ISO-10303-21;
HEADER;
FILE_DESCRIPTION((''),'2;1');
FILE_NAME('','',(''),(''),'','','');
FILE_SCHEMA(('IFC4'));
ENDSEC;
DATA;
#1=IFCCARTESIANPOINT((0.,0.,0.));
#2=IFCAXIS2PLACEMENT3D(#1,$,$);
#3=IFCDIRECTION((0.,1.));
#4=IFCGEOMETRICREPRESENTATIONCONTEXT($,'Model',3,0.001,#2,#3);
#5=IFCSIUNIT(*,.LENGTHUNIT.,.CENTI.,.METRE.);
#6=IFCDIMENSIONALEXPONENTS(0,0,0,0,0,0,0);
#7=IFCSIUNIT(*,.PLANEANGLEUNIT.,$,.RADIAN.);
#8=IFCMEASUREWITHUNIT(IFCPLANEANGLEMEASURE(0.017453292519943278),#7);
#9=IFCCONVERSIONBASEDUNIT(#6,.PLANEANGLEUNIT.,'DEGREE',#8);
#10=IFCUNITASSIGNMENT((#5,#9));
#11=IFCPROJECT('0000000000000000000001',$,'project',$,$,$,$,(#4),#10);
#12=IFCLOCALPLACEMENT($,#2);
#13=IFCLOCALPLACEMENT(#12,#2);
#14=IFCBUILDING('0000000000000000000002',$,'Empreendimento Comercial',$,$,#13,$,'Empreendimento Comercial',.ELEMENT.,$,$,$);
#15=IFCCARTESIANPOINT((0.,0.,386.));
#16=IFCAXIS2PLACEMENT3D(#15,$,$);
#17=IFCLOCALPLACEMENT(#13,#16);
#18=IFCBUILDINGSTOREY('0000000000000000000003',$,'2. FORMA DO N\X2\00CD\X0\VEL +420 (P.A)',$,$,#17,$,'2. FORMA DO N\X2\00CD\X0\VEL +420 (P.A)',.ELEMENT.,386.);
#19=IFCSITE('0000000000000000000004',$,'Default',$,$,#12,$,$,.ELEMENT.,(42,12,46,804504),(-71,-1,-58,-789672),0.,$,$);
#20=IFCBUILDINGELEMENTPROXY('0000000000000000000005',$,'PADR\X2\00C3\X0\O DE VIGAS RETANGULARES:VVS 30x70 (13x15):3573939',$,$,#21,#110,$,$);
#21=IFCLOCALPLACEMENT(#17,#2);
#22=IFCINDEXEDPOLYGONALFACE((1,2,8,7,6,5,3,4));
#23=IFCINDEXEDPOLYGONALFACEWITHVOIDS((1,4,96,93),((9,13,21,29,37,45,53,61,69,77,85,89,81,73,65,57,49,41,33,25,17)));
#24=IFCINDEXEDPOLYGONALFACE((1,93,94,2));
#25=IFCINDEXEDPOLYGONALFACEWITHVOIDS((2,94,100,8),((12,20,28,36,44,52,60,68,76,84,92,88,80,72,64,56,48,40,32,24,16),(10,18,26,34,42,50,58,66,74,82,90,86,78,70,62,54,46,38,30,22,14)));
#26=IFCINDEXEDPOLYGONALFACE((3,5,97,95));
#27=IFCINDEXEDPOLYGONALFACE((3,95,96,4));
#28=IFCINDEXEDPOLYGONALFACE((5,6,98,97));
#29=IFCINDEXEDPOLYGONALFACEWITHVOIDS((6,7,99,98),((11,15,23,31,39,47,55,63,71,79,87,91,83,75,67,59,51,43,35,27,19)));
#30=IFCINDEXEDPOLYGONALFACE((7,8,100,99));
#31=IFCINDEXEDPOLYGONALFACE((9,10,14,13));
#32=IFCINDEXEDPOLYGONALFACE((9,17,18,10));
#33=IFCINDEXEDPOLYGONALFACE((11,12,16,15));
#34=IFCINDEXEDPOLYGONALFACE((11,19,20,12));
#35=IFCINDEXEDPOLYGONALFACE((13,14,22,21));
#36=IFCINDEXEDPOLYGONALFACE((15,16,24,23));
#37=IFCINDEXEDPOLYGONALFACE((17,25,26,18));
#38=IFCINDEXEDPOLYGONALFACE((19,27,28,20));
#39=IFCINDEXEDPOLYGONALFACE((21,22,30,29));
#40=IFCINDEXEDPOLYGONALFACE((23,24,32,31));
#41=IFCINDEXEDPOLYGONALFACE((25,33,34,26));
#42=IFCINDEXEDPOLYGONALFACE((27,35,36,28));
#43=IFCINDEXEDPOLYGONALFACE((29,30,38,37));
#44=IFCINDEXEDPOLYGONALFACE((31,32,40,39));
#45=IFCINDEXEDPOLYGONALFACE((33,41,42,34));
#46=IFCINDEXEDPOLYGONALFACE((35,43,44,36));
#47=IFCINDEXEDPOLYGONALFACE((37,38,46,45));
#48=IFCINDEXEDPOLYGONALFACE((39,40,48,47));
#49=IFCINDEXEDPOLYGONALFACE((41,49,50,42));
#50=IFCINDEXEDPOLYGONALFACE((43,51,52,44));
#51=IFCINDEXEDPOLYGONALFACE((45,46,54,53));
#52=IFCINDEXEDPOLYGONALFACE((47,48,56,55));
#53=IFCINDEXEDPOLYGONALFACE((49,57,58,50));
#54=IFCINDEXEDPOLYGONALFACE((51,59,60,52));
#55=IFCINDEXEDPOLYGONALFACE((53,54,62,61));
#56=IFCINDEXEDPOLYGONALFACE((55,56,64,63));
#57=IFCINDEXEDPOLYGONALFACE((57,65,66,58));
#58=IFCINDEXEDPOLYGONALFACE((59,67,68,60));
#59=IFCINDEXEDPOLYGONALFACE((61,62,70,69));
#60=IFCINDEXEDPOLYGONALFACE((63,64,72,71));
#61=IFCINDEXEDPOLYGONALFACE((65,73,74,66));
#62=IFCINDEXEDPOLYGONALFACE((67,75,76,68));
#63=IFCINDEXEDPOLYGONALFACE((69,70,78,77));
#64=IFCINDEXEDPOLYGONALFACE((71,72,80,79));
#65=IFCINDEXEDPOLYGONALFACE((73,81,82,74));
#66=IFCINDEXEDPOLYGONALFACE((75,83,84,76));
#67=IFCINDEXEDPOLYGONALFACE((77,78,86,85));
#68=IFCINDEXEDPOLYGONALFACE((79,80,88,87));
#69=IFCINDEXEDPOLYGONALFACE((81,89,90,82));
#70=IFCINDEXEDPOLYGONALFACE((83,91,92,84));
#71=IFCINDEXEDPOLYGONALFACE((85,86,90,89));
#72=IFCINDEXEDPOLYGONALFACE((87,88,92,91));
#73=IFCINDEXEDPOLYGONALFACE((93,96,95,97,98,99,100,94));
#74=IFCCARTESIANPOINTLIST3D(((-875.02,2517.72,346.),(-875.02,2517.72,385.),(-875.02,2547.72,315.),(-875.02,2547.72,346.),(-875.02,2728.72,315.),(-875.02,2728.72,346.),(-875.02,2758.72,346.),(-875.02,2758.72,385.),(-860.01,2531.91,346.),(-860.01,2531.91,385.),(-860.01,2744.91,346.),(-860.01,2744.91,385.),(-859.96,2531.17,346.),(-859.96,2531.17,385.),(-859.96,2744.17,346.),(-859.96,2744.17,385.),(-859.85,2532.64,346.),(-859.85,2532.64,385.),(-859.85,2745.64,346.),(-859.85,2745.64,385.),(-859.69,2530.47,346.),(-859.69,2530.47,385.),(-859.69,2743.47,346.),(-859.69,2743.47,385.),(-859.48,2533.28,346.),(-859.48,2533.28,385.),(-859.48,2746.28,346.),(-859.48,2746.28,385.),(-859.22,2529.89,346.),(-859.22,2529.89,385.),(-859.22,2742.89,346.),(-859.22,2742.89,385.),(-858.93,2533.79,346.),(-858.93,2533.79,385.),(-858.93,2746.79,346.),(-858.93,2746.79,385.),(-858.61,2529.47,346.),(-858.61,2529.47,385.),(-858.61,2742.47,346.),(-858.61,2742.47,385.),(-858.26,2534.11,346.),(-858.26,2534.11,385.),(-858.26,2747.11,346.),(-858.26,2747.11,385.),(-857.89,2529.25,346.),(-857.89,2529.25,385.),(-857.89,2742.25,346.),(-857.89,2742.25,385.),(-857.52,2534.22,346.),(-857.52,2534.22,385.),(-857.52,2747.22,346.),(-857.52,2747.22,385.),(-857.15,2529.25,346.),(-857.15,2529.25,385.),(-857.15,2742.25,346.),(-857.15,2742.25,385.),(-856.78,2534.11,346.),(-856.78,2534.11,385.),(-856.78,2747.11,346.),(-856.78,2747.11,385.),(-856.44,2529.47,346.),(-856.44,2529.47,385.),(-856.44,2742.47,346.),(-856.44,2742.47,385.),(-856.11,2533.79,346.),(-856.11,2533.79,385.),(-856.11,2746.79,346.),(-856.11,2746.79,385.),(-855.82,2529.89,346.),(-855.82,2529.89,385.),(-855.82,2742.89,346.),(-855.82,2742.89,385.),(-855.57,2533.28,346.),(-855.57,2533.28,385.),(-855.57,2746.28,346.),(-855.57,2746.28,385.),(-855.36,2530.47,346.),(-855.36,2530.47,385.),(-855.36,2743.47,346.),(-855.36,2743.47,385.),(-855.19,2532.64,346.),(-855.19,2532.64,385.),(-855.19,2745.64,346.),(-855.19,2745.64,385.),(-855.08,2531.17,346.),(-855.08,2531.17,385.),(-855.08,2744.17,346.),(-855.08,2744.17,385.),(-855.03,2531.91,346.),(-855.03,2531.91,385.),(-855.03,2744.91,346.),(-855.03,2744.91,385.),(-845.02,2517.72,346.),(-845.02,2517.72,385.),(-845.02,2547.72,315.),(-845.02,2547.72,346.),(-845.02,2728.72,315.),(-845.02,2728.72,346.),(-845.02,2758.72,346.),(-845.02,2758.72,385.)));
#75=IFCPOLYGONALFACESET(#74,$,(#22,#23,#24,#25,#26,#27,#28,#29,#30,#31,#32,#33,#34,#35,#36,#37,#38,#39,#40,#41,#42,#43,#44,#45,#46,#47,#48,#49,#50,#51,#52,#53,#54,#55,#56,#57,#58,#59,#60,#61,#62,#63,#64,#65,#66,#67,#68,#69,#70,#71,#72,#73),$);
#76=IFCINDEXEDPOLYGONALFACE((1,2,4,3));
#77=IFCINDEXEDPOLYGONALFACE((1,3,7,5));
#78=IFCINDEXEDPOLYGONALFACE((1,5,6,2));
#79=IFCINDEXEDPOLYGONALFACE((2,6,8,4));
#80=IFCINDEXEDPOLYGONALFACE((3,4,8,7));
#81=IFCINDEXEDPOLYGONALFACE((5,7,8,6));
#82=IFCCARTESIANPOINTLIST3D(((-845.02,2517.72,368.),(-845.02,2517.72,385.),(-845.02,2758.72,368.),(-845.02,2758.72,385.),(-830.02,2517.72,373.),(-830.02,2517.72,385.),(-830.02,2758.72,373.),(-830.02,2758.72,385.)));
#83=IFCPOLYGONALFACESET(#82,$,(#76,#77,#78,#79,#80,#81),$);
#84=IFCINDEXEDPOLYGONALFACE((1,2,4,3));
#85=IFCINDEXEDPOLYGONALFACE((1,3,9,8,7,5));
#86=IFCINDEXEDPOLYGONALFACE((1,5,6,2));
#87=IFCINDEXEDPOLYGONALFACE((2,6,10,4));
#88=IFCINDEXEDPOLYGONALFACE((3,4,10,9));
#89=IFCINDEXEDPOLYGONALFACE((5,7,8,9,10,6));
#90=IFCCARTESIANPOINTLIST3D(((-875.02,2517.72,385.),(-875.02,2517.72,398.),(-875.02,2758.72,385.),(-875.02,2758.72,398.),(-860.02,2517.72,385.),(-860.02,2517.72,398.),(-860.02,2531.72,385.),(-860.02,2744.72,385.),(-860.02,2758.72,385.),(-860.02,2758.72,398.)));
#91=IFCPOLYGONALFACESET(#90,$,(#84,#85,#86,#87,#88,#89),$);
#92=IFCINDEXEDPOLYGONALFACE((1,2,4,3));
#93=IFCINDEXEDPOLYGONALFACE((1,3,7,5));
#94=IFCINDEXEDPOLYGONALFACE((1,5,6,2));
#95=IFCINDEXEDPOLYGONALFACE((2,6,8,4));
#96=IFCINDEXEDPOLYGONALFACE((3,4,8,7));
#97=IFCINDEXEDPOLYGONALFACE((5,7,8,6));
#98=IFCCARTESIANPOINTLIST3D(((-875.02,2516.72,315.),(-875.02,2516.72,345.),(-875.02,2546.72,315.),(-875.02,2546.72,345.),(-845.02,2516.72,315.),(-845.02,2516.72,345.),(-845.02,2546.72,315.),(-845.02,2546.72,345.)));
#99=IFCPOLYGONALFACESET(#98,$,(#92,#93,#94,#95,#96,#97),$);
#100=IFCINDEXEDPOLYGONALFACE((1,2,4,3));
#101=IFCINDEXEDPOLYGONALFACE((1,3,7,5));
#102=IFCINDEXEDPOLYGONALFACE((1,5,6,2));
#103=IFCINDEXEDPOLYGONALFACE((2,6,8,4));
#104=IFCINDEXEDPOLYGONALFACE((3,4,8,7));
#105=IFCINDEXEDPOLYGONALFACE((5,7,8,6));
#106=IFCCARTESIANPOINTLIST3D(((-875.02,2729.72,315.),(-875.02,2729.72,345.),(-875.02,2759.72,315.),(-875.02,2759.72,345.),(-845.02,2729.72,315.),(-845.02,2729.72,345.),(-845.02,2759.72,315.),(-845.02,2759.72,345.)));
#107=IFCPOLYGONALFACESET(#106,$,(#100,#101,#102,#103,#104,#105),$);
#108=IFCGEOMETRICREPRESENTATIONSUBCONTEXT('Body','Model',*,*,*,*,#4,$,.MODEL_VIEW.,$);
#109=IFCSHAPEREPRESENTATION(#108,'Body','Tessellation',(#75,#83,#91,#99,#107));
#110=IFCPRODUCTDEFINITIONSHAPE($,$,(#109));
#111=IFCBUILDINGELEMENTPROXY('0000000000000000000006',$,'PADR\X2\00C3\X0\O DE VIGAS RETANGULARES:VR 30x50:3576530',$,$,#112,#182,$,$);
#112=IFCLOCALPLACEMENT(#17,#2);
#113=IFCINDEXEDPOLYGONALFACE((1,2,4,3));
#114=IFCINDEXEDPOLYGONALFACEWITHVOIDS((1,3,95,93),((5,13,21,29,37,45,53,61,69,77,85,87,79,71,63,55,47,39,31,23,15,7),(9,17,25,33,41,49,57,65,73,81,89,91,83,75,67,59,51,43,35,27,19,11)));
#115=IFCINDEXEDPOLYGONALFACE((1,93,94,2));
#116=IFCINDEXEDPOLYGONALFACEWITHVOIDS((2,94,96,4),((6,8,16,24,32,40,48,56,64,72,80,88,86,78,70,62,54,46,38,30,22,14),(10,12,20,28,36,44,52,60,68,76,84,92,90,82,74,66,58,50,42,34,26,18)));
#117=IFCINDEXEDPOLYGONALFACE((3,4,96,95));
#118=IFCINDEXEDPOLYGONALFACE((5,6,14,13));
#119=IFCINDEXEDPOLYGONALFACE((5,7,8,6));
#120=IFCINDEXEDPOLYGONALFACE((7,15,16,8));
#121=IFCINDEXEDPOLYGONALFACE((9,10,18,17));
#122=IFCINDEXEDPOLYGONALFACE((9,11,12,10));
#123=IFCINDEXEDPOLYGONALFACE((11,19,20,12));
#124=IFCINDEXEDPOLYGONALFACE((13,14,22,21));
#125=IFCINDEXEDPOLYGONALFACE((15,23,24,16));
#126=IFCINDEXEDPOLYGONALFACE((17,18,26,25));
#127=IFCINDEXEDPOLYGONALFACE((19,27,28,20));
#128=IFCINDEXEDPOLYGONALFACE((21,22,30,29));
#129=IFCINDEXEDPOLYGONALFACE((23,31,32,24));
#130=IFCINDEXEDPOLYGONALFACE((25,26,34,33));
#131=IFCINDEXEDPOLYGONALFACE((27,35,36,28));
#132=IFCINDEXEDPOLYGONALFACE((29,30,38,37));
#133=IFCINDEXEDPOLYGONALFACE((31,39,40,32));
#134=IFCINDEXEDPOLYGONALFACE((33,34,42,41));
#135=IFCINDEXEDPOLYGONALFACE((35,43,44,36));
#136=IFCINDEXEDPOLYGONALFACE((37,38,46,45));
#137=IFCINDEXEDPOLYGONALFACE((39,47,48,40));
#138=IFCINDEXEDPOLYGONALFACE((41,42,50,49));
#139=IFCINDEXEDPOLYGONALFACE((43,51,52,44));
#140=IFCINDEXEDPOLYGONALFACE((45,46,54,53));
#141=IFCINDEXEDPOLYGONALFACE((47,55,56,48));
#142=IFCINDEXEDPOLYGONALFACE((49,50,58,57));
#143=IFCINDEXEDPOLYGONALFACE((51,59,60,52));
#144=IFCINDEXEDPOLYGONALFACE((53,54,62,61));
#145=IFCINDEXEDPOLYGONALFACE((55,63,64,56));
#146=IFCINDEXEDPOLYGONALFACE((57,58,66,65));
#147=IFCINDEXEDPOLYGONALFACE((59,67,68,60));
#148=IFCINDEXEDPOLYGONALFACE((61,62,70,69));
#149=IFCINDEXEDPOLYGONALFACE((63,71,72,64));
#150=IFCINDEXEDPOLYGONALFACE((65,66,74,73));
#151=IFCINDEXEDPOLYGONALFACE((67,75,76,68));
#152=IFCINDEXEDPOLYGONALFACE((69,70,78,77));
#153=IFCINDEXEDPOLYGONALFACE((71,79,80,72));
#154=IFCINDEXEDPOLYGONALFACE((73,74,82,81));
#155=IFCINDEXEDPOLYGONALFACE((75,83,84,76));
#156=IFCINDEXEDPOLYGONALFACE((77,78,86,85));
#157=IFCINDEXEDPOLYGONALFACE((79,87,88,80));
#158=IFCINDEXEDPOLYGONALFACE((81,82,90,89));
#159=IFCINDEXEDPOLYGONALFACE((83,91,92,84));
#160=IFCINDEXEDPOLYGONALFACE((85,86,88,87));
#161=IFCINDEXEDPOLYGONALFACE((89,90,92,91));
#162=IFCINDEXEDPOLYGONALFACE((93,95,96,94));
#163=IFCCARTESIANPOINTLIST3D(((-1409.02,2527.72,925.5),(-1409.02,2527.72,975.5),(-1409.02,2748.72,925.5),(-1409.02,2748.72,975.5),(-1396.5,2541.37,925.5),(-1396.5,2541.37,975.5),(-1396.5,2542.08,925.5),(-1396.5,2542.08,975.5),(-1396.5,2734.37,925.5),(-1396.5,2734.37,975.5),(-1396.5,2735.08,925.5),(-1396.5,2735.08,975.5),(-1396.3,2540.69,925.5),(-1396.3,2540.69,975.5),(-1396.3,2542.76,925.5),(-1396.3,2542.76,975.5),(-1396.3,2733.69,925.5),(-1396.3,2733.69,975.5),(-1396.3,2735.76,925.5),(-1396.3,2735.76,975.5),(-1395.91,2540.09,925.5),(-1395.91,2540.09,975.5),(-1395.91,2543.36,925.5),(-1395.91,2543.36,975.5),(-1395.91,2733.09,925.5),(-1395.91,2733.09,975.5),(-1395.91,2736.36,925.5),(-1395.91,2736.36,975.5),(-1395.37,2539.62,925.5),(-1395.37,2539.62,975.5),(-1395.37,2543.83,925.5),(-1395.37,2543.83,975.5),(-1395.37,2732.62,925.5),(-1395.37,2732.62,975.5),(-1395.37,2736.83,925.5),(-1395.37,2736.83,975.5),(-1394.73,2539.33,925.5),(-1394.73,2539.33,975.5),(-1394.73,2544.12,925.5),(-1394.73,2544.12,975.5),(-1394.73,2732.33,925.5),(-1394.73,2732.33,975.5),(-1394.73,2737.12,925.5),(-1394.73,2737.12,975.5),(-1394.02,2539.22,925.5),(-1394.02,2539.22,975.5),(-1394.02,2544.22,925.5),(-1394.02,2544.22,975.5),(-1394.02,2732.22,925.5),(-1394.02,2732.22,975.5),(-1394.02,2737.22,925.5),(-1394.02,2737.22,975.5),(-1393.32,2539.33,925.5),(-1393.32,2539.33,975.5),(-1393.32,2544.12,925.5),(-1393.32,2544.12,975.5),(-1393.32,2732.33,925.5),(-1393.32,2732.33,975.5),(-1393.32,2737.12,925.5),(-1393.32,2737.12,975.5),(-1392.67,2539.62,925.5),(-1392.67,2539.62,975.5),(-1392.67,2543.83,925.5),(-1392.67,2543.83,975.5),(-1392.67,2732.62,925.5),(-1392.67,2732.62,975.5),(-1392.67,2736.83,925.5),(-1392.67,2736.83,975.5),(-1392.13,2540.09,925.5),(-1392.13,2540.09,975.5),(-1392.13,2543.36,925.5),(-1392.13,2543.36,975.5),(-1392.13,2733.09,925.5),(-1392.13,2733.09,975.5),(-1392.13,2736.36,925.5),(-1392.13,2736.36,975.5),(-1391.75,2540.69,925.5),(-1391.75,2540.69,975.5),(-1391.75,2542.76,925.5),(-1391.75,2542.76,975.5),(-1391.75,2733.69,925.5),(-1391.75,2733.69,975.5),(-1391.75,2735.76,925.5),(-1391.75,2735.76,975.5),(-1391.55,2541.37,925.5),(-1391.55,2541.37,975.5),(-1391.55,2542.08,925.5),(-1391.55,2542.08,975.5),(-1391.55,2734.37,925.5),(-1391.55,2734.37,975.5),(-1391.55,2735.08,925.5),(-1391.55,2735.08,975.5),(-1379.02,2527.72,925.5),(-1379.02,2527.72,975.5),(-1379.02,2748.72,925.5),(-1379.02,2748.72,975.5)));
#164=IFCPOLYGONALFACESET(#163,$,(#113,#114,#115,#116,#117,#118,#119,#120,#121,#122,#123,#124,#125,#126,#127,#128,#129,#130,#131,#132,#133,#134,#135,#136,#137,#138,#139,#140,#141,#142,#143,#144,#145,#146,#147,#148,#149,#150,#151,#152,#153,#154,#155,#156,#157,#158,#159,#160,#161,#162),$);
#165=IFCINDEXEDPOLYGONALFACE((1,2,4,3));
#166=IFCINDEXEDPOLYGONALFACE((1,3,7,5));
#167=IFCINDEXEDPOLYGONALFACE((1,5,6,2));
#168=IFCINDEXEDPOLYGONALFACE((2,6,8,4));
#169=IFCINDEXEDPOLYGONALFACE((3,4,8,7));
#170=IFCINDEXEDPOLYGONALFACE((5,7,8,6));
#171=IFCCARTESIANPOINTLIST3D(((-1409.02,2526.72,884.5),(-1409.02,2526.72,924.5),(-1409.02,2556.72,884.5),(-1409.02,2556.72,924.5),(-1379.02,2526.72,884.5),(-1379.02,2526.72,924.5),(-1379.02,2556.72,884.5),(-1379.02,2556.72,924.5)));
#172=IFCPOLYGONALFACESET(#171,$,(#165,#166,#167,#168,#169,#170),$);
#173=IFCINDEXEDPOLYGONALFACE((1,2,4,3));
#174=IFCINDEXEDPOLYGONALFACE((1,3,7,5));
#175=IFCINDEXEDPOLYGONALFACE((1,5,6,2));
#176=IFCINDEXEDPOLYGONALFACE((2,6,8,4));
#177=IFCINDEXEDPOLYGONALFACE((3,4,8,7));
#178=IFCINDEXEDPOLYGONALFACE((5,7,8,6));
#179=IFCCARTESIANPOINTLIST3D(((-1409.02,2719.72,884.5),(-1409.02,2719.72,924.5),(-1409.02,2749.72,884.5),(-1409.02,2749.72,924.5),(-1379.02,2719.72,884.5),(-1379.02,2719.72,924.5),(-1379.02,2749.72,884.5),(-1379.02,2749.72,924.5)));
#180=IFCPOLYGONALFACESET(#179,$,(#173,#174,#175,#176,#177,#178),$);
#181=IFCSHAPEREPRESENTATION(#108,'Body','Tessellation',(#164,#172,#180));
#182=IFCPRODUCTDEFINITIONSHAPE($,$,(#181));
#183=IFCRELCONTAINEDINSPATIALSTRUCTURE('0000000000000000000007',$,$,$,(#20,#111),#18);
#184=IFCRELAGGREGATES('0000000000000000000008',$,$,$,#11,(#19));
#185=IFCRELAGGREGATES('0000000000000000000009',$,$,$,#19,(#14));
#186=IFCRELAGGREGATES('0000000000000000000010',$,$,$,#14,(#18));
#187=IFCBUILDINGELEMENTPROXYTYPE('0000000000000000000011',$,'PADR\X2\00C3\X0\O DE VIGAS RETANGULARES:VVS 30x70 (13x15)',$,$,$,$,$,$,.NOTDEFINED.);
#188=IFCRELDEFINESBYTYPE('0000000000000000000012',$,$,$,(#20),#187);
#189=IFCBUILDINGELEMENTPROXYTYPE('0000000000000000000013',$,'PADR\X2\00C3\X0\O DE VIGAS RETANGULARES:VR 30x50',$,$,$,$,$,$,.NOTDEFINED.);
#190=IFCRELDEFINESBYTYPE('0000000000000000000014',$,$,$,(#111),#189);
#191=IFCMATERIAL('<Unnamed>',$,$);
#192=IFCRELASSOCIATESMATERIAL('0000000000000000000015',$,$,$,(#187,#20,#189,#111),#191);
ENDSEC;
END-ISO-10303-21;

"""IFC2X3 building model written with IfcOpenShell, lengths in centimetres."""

from ifc_helpers import new_model, entity, si_unit, converted_unit, direction, frame, frame_2d, origin, origin_2d_with_axis, place, context, subcontext, project, spatial, polyline, circle_curve, parameter, trimmed, segment, composite_curve, rectangle, circle, outline, extrude, source, transform, mapped, material, type_object, type_shapes, element, save


model = new_model("IFC2X3")

# Units and contexts
model_context = context("Model", 3, precision=0.001, world=origin(), true_north=direction((0.0, 1.0)))
body_context = subcontext(model_context, "Body", "Model", "MODEL_VIEW")
ifc_project = project(units=[si_unit("LENGTHUNIT", "METRE", prefix="CENTI"), converted_unit("PLANEANGLEUNIT", "DEGREE", entity("IfcPlaneAngleMeasure", 0.017453292519943278), si_unit("PLANEANGLEUNIT", "RADIAN"), dimensions=[0, 0, 0, 0, 0, 0, 0])], contexts=[model_context])

# Site, building, storey
site_placement = place(None, origin())
site = spatial("IfcSite", under=ifc_project, at=site_placement, Name="Default", CompositionType="ELEMENT", RefLatitude=(42, 12, 46, 804504), RefLongitude=(-71, -1, -58, -789672), RefElevation=0.0)
building_placement = place(site_placement, origin())
building = spatial("IfcBuilding", under=site, at=building_placement, Name="Empreendimento Comercial", LongName="Empreendimento Comercial", CompositionType="ELEMENT")
storey_placement = place(building_placement, frame((0.0, 0.0, 386.0)))
storey = spatial("IfcBuildingStorey", under=building, at=storey_placement, Name="2. FORMA DO NÍVEL +420 (P.A)", LongName="2. FORMA DO NÍVEL +420 (P.A)", CompositionType="ELEMENT", Elevation=386.0)

# Shared definitions
ifc_material_1 = material(Name="<Unnamed>")

# Building element proxy, openings
building_element_proxy_type_1 = type_object("IfcBuildingElementProxyType", Name="PADRÃO DE VIGAS RETANGULARES:VVS 30x70 (13x15)", PredefinedType="NOTDEFINED", material=ifc_material_1)
shared_shape_1 = source(origin(), body_context, "Body", "SweptSolid", [
    extrude(outline(polyline([(-37.0, -120.5), (2.0, -120.5), (2.0, -90.5), (33.0, -90.5), (33.0, 90.5), (2.0, 90.5), (2.0, 120.5), (-37.0, 120.5), (-37.0, -120.5)])), frame((-875.02, 2638.22, 734.0), z_axis=(1.0, 0.0, 0.0), x_axis=(0.0, 0.0, -1.0)), (0.0, 0.0, 1.0), 30.0),
    extrude(outline(polyline([(-7.25, -7.5), (4.75, -7.5), (9.75, 7.5), (-7.25, 7.5), (-7.25, -7.5)])), frame((-837.52, 2517.72, 763.75), z_axis=(0.0, 1.0, 0.0), x_axis=(0.0, 0.0, -1.0)), (0.0, 0.0, 1.0), 241.0),
    extrude(rectangle(XDim=241.0, YDim=15.0, at=origin_2d_with_axis()), frame((-867.52, 2638.22, 771.0), z_axis=(0.0, 0.0, 1.0), x_axis=(0.0, -1.0, 0.0)), (0.0, 0.0, 1.0), 13.0),
    extrude(rectangle(XDim=30.0, YDim=30.0, at=frame_2d((0.0, 0.0), x_axis=(1.0, 0.0))), frame((-860.02, 2531.72, 701.0), z_axis=(0.0, 0.0, 1.0), x_axis=(-1.0, 0.0, 0.0)), (0.0, 0.0, 1.0), 30.0),
    extrude(rectangle(XDim=30.0, YDim=30.0, at=frame_2d((0.0, 0.0), x_axis=(1.0, 0.0))), frame((-860.02, 2744.72, 701.0), z_axis=(0.0, 0.0, 1.0), x_axis=(-1.0, 0.0, 0.0)), (0.0, 0.0, 1.0), 30.0),
])
type_shapes(building_element_proxy_type_1, [shared_shape_1])
proxy_1_placement = place(storey_placement, frame((0.0, 0.0, -386.0)))
proxy_1 = element("IfcBuildingElementProxy", 1, at=proxy_1_placement, inside=storey, type_object=building_element_proxy_type_1, material=ifc_material_1, Name="PADRÃO DE VIGAS RETANGULARES:VVS 30x70 (13x15):3573939", context=body_context, shape_type="MappedRepresentation", body=[
    mapped(shared_shape_1, transform((0.0, 0.0, 0.0), scale=1.0)),
])
opening_1_placement = place(storey_placement, frame((0.0, 0.0, -386.0)))
element("IfcOpeningElement", 2, at=opening_1_placement, cuts=proxy_1, ObjectType="Opening", context=body_context, shape_type="SweptSolid", body=[
    extrude(circle(Radius=2.5, at=origin_2d_with_axis()), frame((-857.52, 2744.72, 732.0), z_axis=(0.0, 0.0, 1.0), x_axis=(0.0, 1.0, 0.0)), (0.0, 0.0, 1.0), 39.0),
])
opening_2_placement = place(storey_placement, frame((0.0, 0.0, -386.0)))
element("IfcOpeningElement", 3, at=opening_2_placement, cuts=proxy_1, ObjectType="Opening", context=body_context, shape_type="SweptSolid", body=[
    extrude(circle(Radius=2.5, at=origin_2d_with_axis()), frame((-857.52, 2531.72, 732.0), z_axis=(0.0, 0.0, 1.0), x_axis=(0.0, 1.0, 0.0)), (0.0, 0.0, 1.0), 39.0),
])

# Building element proxy
building_element_proxy_type_2 = type_object("IfcBuildingElementProxyType", Name="PADRÃO DE VIGAS RETANGULARES:VR 30x50", PredefinedType="NOTDEFINED", material=ifc_material_1)
shared_shape_2 = source(origin(), body_context, "Body", "SweptSolid", [
    extrude(outline(polyline([(-110.5, -15.0), (110.5, -15.0), (110.5, 15.0), (-110.5, 15.0), (-110.5, -15.0)]), holes=[composite_curve([segment(trimmed(circle_curve(frame_2d((96.5, 0.0), x_axis=(-1.0, 0.0)), 2.5), [parameter(0.0)], [parameter(180.0)], True, "PARAMETER"), False, "CONTINUOUS"), segment(trimmed(circle_curve(frame_2d((96.5, 0.0), x_axis=(-1.0, 0.0)), 2.5), [parameter(180.0)], [parameter(0.0)], True, "PARAMETER"), False, "CONTINUOUS")], self_intersect=False), composite_curve([segment(trimmed(circle_curve(frame_2d((-96.5, 0.0), x_axis=(-1.0, 0.0)), 2.5), [parameter(0.0)], [parameter(180.0)], True, "PARAMETER"), False, "CONTINUOUS"), segment(trimmed(circle_curve(frame_2d((-96.5, 0.0), x_axis=(-1.0, 0.0)), 2.5), [parameter(180.0)], [parameter(0.0)], True, "PARAMETER"), False, "CONTINUOUS")], self_intersect=False)]), frame((-1394.02, 2638.22, 1311.5), z_axis=(0.0, 0.0, 1.0), x_axis=(0.0, -1.0, 0.0)), (0.0, 0.0, 1.0), 50.0),
    extrude(rectangle(XDim=30.0, YDim=30.0, at=frame_2d((0.0, 0.0), x_axis=(1.0, 0.0))), frame((-1394.02, 2541.72, 1270.5), z_axis=(0.0, 0.0, 1.0), x_axis=(-1.0, 0.0, 0.0)), (0.0, 0.0, 1.0), 40.0),
    extrude(rectangle(XDim=30.0, YDim=30.0, at=frame_2d((0.0, 0.0), x_axis=(1.0, 0.0))), frame((-1394.02, 2734.72, 1270.5), z_axis=(0.0, 0.0, 1.0), x_axis=(-1.0, 0.0, 0.0)), (0.0, 0.0, 1.0), 40.0),
])
type_shapes(building_element_proxy_type_2, [shared_shape_2])
proxy_2_placement = place(storey_placement, frame((0.0, 0.0, -386.0)))
element("IfcBuildingElementProxy", 4, at=proxy_2_placement, inside=storey, type_object=building_element_proxy_type_2, material=ifc_material_1, Name="PADRÃO DE VIGAS RETANGULARES:VR 30x50:3576530", context=body_context, shape_type="MappedRepresentation", body=[
    mapped(shared_shape_2, transform((0.0, 0.0, 0.0), scale=1.0)),
])

save(model, "model.ifc")
